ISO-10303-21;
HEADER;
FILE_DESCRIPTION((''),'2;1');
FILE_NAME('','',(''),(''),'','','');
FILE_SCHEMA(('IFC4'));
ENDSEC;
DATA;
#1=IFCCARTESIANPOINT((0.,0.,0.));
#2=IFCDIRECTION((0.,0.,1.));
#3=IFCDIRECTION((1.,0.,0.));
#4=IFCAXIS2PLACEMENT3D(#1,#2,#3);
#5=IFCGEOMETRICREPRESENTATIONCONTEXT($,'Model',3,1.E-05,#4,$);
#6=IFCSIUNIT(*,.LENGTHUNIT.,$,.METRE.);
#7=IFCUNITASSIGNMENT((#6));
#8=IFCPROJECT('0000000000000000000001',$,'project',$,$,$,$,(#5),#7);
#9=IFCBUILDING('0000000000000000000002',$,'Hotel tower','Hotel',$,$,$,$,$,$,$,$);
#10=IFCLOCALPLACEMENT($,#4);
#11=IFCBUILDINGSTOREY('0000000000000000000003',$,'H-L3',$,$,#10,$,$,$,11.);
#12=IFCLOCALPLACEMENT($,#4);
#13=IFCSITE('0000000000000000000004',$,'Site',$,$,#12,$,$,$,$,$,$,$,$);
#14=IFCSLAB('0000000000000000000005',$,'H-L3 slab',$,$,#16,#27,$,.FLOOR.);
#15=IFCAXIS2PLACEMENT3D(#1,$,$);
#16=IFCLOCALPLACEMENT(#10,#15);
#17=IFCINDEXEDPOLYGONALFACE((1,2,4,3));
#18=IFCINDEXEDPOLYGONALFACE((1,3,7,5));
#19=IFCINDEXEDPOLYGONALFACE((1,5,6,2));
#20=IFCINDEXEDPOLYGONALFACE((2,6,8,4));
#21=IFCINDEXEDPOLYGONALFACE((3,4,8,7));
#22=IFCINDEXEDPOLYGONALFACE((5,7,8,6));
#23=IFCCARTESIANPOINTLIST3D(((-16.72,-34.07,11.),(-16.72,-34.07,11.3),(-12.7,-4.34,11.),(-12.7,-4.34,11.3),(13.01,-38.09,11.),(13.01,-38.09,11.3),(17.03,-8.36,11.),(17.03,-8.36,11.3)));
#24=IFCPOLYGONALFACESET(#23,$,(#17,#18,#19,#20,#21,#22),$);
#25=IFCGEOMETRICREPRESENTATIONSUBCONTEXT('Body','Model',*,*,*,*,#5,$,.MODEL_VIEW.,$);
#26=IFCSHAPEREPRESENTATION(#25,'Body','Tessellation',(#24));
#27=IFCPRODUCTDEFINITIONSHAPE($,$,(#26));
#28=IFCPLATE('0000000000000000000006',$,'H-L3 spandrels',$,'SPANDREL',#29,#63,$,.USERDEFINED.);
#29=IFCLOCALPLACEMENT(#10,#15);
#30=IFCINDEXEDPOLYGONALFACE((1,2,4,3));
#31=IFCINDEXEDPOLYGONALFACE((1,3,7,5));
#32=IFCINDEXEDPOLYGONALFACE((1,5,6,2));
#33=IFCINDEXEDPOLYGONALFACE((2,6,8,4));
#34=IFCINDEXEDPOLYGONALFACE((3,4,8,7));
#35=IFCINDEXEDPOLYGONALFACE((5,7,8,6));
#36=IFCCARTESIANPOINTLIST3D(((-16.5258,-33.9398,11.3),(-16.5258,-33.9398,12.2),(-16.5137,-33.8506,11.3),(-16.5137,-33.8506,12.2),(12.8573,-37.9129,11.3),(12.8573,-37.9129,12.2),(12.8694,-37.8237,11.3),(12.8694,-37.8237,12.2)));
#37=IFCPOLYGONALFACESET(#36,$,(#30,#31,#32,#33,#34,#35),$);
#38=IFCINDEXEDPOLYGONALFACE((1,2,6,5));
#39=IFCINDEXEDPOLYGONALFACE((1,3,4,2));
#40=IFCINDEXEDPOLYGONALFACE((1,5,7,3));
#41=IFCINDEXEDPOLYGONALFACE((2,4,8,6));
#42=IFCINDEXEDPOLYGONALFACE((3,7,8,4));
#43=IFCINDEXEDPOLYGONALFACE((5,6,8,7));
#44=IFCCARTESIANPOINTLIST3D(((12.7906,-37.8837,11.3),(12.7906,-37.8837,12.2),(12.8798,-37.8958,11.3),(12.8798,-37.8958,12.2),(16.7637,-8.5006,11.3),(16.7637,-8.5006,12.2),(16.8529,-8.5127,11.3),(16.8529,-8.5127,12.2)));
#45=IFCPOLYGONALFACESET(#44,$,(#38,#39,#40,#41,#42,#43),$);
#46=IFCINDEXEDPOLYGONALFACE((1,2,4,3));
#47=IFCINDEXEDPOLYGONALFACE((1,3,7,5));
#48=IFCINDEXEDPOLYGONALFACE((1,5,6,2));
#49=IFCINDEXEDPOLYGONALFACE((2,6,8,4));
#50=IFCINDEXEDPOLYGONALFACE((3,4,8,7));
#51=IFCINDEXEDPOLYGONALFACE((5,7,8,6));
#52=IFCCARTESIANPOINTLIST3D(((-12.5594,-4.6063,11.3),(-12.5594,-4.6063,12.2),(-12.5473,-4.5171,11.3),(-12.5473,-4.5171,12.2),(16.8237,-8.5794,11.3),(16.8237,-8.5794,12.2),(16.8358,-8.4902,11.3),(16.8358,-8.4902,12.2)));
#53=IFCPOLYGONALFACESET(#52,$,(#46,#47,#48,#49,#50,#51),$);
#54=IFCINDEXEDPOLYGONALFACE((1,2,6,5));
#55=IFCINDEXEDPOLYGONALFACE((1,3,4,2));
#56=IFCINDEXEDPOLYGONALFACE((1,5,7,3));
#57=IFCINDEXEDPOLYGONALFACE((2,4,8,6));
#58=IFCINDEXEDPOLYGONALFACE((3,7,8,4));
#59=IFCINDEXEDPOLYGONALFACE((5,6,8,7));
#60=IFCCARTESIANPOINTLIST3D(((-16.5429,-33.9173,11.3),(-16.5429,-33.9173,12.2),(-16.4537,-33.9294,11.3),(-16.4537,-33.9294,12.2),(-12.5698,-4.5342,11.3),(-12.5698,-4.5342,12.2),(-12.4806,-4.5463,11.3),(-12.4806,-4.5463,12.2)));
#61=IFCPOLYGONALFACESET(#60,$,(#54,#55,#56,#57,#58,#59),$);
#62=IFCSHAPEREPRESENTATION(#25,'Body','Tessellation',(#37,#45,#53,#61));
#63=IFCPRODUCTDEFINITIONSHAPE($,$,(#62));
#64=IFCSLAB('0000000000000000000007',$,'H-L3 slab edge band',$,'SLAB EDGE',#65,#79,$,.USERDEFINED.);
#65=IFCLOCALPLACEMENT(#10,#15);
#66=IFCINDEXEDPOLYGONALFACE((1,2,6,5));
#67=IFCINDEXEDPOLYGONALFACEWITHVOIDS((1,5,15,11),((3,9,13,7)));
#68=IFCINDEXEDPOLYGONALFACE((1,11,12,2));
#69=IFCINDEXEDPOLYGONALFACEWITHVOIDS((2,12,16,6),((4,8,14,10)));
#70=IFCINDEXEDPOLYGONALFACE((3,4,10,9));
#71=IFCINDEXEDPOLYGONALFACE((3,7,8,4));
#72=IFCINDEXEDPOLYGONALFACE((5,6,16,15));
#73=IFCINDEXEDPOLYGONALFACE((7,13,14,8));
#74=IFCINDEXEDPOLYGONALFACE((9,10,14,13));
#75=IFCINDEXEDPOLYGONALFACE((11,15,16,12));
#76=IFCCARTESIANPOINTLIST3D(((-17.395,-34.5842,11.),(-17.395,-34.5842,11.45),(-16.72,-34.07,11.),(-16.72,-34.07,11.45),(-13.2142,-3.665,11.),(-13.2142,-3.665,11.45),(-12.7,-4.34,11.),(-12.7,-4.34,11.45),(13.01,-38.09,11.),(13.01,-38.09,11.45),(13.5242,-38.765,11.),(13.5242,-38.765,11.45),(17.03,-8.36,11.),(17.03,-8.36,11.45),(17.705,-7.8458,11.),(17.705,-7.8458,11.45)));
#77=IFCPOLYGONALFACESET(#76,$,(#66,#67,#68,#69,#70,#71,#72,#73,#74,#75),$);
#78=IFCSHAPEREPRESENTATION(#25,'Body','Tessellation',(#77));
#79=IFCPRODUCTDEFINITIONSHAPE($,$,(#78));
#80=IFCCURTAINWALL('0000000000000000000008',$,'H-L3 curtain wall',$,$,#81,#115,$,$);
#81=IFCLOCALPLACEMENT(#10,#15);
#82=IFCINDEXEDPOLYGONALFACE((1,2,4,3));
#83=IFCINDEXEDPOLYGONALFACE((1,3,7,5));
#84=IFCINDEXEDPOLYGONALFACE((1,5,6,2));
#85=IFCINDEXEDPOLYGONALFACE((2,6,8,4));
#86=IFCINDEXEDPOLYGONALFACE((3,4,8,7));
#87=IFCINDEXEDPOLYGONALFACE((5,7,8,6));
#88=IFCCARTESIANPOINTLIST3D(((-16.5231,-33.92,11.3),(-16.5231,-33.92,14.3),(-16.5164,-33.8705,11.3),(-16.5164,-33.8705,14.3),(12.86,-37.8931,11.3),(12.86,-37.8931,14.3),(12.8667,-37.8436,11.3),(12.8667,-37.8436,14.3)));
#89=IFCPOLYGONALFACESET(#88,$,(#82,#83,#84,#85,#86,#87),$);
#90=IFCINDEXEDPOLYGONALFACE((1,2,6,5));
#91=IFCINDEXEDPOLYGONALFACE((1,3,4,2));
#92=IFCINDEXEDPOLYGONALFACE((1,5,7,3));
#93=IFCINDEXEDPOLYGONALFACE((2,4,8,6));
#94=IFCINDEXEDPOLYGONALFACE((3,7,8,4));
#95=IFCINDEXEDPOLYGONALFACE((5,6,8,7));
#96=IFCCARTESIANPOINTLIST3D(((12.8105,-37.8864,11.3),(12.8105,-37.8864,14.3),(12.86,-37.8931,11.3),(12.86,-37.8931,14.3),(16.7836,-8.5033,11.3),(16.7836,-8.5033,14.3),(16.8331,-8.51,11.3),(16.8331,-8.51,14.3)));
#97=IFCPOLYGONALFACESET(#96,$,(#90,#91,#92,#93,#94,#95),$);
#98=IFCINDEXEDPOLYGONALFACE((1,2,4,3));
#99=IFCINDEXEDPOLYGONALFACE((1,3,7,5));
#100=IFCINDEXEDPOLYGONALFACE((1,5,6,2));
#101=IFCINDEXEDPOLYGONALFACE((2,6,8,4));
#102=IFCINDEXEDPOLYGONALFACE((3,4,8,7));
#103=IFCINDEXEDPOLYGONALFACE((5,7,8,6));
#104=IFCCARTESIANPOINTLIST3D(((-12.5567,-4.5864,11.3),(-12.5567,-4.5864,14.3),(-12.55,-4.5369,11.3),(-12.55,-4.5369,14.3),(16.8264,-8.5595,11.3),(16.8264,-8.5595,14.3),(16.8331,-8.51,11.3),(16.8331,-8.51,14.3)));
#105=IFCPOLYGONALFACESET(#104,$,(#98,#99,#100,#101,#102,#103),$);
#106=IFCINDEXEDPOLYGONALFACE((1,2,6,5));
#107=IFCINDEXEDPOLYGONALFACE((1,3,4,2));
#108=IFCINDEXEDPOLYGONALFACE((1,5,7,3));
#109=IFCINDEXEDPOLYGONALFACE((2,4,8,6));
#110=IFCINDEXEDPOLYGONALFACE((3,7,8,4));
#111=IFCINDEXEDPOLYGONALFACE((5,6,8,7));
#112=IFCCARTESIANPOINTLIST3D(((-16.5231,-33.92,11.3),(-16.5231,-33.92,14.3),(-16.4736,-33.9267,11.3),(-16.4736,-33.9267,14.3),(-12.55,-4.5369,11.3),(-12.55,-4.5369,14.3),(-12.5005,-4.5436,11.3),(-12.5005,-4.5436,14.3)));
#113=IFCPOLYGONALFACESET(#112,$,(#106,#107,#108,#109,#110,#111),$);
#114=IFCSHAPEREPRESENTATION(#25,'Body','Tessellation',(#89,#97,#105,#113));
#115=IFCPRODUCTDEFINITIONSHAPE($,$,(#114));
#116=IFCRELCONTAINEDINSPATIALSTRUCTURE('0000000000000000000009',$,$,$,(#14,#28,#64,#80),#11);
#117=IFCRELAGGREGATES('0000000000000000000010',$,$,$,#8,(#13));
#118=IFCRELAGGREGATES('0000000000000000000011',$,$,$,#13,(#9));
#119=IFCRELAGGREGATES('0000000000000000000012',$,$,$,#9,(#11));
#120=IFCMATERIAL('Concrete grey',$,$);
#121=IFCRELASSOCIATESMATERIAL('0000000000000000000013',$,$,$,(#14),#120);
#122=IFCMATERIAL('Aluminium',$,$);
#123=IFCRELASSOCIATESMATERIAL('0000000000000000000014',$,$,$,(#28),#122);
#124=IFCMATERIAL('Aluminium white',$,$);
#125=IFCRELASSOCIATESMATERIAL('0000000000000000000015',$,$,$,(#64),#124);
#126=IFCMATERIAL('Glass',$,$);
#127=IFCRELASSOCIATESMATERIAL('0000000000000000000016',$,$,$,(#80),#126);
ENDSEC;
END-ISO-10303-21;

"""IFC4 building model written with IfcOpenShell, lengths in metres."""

from ifc_helpers import new_model, si_unit, frame, origin_with_axes, place, context, subcontext, project, spatial, polyline, outline, extrude, material, element, save


model = new_model("IFC4")

# Units and contexts
model_context = context("Model", 3, precision=1e-05, world=origin_with_axes())
body_context = subcontext(model_context, "Body", "Model", "MODEL_VIEW")
ifc_project = project(units=[si_unit("LENGTHUNIT", "METRE")], contexts=[model_context])

# Site, building, storey
site_placement = place(None, origin_with_axes())
site = spatial("IfcSite", under=ifc_project, at=site_placement, Name="Site")
building = spatial("IfcBuilding", under=site, Name="Hotel tower", Description="Hotel")
storey_placement = place(None, origin_with_axes())
storey = spatial("IfcBuildingStorey", under=building, at=storey_placement, Name="H-L3", Elevation=11.0)

# Shared definitions
ifc_material_1 = material(Name="Aluminium")

# Slab
ifc_material_2 = material(Name="Concrete grey")
slab_1_placement = place(storey_placement, origin_with_axes())
element("IfcSlab", 1, at=slab_1_placement, inside=storey, material=ifc_material_2, Name="H-L3 slab", PredefinedType="FLOOR", context=body_context, shape_type="SweptSolid", body=[
    extrude(outline(polyline([(-16.72, -34.07), (13.01, -38.09), (17.03, -8.36), (-12.7, -4.34), (-16.72, -34.07)])), frame((0.0, 0.0, 11.0), z_axis=(0.0, 0.0, 1.0), x_axis=(1.0, 0.0, 0.0)), (0.0, 0.0, 1.0), 0.3),
])

# Plate
plate_placement = place(storey_placement, origin_with_axes())
element("IfcPlate", 2, at=plate_placement, inside=storey, material=ifc_material_1, Name="H-L3 spandrels", ObjectType="SPANDREL", PredefinedType="USERDEFINED", context=body_context, shape_type="SweptSolid", body=[
    extrude(outline(polyline([(-16.5258, -33.9398), (12.8573, -37.9129), (12.8694, -37.8237), (-16.5137, -33.8506), (-16.5258, -33.9398)])), frame((0.0, 0.0, 11.3), z_axis=(0.0, 0.0, 1.0), x_axis=(1.0, 0.0, 0.0)), (0.0, 0.0, 1.0), 0.9),
    extrude(outline(polyline([(12.8798, -37.8958), (16.8529, -8.5127), (16.7637, -8.5006), (12.7906, -37.8837), (12.8798, -37.8958)])), frame((0.0, 0.0, 11.3), z_axis=(0.0, 0.0, 1.0), x_axis=(1.0, 0.0, 0.0)), (0.0, 0.0, 1.0), 0.9),
    extrude(outline(polyline([(16.8358, -8.4902), (-12.5473, -4.5171), (-12.5594, -4.6063), (16.8237, -8.5794), (16.8358, -8.4902)])), frame((0.0, 0.0, 11.3), z_axis=(0.0, 0.0, 1.0), x_axis=(1.0, 0.0, 0.0)), (0.0, 0.0, 1.0), 0.9),
    extrude(outline(polyline([(-12.5698, -4.5342), (-16.5429, -33.9173), (-16.4537, -33.9294), (-12.4806, -4.5463), (-12.5698, -4.5342)])), frame((0.0, 0.0, 11.3), z_axis=(0.0, 0.0, 1.0), x_axis=(1.0, 0.0, 0.0)), (0.0, 0.0, 1.0), 0.9),
])

# Slab
ifc_material_3 = material(Name="Aluminium white")
slab_2_placement = place(storey_placement, origin_with_axes())
element("IfcSlab", 3, at=slab_2_placement, inside=storey, material=ifc_material_3, Name="H-L3 slab edge band", ObjectType="SLAB EDGE", PredefinedType="USERDEFINED", context=body_context, shape_type="SweptSolid", body=[
    extrude(outline(polyline([(-17.395, -34.5842), (13.5242, -38.765), (17.705, -7.8458), (-13.2142, -3.665), (-17.395, -34.5842)]), holes=[polyline([(-16.72, -34.07), (13.01, -38.09), (17.03, -8.36), (-12.7, -4.34), (-16.72, -34.07)])]), frame((0.0, 0.0, 11.0), z_axis=(0.0, 0.0, 1.0), x_axis=(1.0, 0.0, 0.0)), (0.0, 0.0, 1.0), 0.45),
])

# Curtain wall
ifc_material_4 = material(Name="Glass")
curtain_wall_placement = place(storey_placement, origin_with_axes())
element("IfcCurtainWall", 4, at=curtain_wall_placement, inside=storey, material=ifc_material_4, Name="H-L3 curtain wall", context=body_context, shape_type="SweptSolid", body=[
    extrude(outline(polyline([(-16.5231, -33.92), (12.86, -37.8931), (12.8667, -37.8436), (-16.5164, -33.8705), (-16.5231, -33.92)])), frame((0.0, 0.0, 11.3), z_axis=(0.0, 0.0, 1.0), x_axis=(1.0, 0.0, 0.0)), (0.0, 0.0, 1.0), 3.0),
    extrude(outline(polyline([(12.86, -37.8931), (16.8331, -8.51), (16.7836, -8.5033), (12.8105, -37.8864), (12.86, -37.8931)])), frame((0.0, 0.0, 11.3), z_axis=(0.0, 0.0, 1.0), x_axis=(1.0, 0.0, 0.0)), (0.0, 0.0, 1.0), 3.0),
    extrude(outline(polyline([(16.8331, -8.51), (-12.55, -4.5369), (-12.5567, -4.5864), (16.8264, -8.5595), (16.8331, -8.51)])), frame((0.0, 0.0, 11.3), z_axis=(0.0, 0.0, 1.0), x_axis=(1.0, 0.0, 0.0)), (0.0, 0.0, 1.0), 3.0),
    extrude(outline(polyline([(-12.55, -4.5369), (-16.5231, -33.92), (-16.4736, -33.9267), (-12.5005, -4.5436), (-12.55, -4.5369)])), frame((0.0, 0.0, 11.3), z_axis=(0.0, 0.0, 1.0), x_axis=(1.0, 0.0, 0.0)), (0.0, 0.0, 1.0), 3.0),
])

save(model, "model.ifc")
